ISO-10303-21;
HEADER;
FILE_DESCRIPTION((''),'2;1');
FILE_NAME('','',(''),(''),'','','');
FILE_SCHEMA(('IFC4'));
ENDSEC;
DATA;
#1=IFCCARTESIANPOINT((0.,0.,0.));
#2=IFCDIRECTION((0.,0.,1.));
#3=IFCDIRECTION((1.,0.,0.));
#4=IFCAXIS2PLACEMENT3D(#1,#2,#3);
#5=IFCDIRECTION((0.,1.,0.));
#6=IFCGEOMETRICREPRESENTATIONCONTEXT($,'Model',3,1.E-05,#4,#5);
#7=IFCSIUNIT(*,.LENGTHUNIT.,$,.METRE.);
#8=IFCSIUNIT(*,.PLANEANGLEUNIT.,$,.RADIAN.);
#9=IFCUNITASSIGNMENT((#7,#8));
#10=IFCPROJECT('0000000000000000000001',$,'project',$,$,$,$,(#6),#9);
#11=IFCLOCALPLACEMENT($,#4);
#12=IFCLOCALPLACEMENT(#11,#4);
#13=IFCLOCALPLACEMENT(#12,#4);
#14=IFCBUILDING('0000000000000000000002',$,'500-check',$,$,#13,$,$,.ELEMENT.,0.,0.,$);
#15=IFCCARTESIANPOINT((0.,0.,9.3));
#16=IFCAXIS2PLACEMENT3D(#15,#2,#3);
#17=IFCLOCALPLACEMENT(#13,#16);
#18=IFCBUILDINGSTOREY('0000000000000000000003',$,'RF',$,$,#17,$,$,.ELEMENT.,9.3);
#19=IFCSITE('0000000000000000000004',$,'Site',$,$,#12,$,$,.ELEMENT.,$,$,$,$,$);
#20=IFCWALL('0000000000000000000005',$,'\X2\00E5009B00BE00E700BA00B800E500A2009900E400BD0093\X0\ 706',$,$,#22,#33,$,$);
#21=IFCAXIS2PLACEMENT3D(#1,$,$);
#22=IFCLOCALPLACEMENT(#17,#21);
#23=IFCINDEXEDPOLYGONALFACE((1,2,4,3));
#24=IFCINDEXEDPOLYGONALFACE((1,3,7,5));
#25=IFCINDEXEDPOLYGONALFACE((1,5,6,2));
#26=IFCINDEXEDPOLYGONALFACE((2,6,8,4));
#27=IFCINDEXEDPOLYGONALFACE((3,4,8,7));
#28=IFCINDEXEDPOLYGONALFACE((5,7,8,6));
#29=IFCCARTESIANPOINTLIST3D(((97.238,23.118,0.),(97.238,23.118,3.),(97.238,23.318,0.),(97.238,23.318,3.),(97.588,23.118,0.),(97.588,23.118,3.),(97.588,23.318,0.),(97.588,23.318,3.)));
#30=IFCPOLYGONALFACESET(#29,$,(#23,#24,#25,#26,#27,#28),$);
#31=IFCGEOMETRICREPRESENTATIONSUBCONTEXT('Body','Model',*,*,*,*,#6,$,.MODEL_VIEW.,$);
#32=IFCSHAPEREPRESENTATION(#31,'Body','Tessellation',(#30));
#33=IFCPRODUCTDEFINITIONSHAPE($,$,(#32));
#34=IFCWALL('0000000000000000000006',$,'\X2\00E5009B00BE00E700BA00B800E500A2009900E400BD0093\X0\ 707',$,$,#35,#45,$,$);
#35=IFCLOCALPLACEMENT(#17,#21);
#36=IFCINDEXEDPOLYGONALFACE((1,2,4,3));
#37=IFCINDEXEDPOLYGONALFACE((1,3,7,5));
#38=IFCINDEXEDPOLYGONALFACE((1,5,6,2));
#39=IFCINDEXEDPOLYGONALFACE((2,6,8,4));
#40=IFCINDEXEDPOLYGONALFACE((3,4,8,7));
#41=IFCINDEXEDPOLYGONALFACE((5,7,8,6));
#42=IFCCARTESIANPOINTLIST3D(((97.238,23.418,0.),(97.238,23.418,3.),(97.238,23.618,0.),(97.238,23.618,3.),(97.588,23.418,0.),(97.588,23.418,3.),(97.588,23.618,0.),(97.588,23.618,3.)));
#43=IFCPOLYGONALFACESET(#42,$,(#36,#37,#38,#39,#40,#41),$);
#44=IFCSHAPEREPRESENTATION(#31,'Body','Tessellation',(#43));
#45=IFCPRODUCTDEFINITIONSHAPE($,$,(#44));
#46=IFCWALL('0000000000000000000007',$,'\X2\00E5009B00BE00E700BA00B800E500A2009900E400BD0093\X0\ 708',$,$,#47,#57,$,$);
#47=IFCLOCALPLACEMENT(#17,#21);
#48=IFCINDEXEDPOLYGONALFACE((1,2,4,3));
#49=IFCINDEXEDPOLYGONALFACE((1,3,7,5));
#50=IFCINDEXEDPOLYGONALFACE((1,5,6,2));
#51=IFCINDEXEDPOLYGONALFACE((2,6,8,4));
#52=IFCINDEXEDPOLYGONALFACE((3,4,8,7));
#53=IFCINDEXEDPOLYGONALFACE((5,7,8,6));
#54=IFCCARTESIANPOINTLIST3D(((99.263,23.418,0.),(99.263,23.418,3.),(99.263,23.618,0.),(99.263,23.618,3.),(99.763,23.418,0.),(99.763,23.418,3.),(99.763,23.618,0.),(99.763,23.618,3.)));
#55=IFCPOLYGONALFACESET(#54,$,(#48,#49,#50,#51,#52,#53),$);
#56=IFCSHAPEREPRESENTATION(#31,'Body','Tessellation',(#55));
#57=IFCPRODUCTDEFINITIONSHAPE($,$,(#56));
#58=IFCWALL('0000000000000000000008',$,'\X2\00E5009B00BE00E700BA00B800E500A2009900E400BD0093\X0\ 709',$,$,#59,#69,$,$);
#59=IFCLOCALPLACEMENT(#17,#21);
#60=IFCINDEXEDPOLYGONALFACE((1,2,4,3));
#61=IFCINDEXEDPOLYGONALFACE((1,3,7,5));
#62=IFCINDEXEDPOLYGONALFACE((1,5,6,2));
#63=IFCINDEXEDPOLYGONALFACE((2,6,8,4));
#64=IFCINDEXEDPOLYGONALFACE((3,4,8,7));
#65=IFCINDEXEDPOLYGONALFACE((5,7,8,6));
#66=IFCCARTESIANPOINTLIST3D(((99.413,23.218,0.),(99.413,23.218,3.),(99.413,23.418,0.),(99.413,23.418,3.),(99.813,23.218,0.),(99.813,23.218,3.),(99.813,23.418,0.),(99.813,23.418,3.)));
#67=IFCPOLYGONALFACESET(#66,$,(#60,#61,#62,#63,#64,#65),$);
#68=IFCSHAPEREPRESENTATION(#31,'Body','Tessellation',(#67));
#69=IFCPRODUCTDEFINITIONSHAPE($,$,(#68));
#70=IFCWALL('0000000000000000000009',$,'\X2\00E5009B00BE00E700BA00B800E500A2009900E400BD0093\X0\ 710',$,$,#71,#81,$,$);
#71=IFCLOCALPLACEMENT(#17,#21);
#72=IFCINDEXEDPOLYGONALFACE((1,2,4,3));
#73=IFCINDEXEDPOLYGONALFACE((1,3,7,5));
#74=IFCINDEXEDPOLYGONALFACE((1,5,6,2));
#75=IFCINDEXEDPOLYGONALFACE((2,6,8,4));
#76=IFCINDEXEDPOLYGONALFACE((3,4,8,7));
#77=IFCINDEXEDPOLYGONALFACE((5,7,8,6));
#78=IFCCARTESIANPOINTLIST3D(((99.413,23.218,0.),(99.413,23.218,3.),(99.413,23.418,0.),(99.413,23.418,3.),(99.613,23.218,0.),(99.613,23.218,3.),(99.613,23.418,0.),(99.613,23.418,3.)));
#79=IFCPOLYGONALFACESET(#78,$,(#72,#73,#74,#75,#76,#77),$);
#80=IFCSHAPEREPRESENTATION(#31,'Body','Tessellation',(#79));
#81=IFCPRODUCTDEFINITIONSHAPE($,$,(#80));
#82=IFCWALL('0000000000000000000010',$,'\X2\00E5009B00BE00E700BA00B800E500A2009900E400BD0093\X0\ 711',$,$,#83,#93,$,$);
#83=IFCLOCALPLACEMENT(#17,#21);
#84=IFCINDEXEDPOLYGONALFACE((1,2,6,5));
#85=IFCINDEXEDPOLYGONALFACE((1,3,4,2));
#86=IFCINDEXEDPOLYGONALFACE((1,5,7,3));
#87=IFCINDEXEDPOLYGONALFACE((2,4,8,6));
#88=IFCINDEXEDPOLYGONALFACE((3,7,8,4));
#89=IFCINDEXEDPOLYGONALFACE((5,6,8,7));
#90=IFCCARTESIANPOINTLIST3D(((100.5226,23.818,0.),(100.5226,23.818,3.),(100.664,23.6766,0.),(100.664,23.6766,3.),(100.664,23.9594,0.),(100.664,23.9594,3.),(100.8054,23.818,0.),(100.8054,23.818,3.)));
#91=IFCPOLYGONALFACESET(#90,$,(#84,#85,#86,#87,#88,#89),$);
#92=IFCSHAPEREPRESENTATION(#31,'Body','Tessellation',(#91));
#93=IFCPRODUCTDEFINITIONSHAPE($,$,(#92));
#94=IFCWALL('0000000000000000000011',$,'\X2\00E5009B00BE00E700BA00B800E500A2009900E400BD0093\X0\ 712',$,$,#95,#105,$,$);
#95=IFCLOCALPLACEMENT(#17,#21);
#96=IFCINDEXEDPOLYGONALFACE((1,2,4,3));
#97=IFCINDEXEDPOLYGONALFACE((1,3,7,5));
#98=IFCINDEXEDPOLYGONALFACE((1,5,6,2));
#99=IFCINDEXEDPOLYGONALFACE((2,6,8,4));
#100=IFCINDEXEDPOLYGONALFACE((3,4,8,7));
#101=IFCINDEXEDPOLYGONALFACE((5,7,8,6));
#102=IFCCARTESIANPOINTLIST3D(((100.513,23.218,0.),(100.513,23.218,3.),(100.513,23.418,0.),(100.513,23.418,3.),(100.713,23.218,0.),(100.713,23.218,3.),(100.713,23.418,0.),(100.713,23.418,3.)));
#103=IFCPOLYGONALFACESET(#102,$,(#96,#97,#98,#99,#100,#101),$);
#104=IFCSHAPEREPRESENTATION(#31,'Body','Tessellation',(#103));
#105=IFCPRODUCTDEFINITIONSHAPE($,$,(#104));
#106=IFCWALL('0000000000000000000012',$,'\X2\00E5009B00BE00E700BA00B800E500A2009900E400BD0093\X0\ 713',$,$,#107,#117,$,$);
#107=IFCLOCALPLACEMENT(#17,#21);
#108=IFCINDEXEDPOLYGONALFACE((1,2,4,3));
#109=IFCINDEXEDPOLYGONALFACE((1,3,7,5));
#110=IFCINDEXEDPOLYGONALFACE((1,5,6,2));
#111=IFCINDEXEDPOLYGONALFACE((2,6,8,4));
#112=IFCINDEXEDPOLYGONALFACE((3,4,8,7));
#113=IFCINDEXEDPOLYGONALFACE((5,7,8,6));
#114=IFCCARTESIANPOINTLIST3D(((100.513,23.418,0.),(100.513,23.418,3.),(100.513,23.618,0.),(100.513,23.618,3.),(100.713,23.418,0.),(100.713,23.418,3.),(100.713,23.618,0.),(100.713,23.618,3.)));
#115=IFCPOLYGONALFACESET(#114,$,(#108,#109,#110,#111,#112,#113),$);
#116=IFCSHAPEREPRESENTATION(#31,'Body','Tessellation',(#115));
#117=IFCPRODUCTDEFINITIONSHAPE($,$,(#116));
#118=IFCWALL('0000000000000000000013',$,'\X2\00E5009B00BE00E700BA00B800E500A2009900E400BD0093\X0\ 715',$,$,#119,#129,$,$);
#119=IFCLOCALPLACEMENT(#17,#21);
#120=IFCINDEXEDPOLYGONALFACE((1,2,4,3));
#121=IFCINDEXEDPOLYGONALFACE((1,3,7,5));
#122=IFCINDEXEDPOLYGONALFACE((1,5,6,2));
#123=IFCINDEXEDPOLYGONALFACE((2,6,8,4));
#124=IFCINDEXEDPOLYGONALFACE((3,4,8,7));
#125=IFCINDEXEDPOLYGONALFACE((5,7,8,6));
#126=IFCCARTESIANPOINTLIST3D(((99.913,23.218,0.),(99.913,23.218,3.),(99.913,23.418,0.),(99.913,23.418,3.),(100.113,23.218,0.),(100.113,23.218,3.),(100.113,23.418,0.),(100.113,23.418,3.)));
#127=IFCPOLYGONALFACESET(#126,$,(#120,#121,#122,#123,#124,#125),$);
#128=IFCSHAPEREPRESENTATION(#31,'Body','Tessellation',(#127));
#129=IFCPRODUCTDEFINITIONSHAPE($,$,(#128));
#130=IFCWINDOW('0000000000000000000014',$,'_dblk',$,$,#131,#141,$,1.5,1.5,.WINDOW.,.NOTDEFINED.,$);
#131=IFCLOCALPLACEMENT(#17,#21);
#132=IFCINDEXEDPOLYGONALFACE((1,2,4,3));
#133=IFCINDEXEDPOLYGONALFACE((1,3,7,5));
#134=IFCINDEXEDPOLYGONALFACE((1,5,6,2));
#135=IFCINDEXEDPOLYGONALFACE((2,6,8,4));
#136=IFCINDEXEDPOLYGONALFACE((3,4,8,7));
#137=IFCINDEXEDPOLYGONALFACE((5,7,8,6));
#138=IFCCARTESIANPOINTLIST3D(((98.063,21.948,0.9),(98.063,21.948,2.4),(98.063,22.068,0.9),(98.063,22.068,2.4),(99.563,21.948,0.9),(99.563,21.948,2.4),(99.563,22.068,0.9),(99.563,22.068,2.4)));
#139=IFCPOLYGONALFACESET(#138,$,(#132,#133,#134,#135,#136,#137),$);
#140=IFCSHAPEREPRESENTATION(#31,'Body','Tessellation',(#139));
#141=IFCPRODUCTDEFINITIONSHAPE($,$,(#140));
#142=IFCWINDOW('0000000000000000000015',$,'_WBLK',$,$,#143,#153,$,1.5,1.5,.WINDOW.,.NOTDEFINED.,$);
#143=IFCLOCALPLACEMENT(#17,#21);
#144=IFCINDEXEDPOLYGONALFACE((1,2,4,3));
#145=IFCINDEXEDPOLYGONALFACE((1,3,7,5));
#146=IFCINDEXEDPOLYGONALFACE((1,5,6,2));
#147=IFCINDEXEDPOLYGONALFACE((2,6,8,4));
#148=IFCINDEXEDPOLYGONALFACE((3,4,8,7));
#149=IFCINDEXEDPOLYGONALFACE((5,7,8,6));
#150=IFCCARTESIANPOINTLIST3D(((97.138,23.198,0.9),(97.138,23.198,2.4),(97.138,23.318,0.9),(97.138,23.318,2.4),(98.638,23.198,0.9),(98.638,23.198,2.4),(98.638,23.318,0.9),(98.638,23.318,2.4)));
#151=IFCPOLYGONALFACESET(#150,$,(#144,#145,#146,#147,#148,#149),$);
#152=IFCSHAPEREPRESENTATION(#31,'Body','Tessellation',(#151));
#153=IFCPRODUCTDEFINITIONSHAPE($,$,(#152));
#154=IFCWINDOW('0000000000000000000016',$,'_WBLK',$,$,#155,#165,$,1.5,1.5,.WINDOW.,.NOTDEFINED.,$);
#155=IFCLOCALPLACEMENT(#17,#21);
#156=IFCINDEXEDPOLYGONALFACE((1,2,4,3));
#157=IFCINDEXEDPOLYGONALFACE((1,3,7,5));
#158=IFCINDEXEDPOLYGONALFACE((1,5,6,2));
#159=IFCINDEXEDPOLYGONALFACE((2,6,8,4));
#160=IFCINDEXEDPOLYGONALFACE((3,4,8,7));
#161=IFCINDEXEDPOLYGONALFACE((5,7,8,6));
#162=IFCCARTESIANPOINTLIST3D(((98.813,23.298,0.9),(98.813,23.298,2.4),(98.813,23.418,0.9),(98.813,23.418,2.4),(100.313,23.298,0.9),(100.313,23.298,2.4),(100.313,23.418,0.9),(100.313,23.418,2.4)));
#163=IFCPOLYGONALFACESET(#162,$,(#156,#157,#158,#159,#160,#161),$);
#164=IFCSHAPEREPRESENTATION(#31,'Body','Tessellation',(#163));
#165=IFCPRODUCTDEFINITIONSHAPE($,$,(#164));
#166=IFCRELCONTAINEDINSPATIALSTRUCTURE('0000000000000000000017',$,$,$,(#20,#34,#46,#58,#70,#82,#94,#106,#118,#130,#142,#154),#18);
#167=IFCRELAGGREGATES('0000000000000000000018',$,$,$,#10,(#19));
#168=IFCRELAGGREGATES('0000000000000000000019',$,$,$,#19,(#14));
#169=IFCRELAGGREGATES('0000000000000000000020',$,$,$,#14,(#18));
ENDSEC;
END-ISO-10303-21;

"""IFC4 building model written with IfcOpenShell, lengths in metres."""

from ifc_helpers import new_model, si_unit, direction, frame, frame_2d, origin_with_axes, place, context, subcontext, project, spatial, rectangle, extrude, element, save


model = new_model("IFC4")

# Units and contexts
model_context = context("Model", 3, precision=1e-05, world=origin_with_axes(), true_north=direction((0.0, 1.0, 0.0)))
body_context = subcontext(model_context, "Body", "Model", "MODEL_VIEW")
ifc_project = project(units=[si_unit("LENGTHUNIT", "METRE"), si_unit("PLANEANGLEUNIT", "RADIAN")], contexts=[model_context])

# Site, building, storey
placement = place(None, origin_with_axes())
site_placement = place(placement, origin_with_axes())
site = spatial("IfcSite", under=ifc_project, at=site_placement, Name="Site", CompositionType="ELEMENT")
building_placement = place(site_placement, origin_with_axes())
building = spatial("IfcBuilding", under=site, at=building_placement, Name="500-check", CompositionType="ELEMENT", ElevationOfRefHeight=0.0, ElevationOfTerrain=0.0)
storey_placement = place(building_placement, frame((0.0, 0.0, 9.3), z_axis=(0.0, 0.0, 1.0), x_axis=(1.0, 0.0, 0.0)))
storey = spatial("IfcBuildingStorey", under=building, at=storey_placement, Name="RF", CompositionType="ELEMENT", Elevation=9.3)

# Walls
for number, where, z_axis, x_axis, name in (
    (1, (97.413, 23.218, 0.0), (0.0, 0.0, 1.0), (1.0, 0.0, 0.0), "å\u009b¾çº¸å¢\u0099ä½\u0093 706"),
    (2, (97.413, 23.518, 0.0), (0.0, 0.0, 1.0), (1.0, 0.0, 0.0), "å\u009b¾çº¸å¢\u0099ä½\u0093 707"),
):
    element("IfcWall", number, at=place(storey_placement, frame(where, z_axis=z_axis, x_axis=x_axis)), inside=storey, Name=name, context=body_context, shape_type="SweptSolid", body=[
        extrude(rectangle(XDim=0.35, YDim=0.2, at=frame_2d((0.0, 0.0), x_axis=(1.0, 0.0, 0.0))), frame((0.0, 0.0, 0.0), z_axis=(0.0, 0.0, 1.0)), (0.0, 0.0, 1.0), 3.0),
    ])
wall_1_placement = place(storey_placement, frame((99.513, 23.518, 0.0), z_axis=(0.0, 0.0, 1.0), x_axis=(1.0, 0.0, 0.0)))
element("IfcWall", 3, at=wall_1_placement, inside=storey, Name="å\u009b¾çº¸å¢\u0099ä½\u0093 708", context=body_context, shape_type="SweptSolid", body=[
    extrude(rectangle(XDim=0.5, YDim=0.2, at=frame_2d((0.0, 0.0), x_axis=(1.0, 0.0, 0.0))), frame((0.0, 0.0, 0.0), z_axis=(0.0, 0.0, 1.0)), (0.0, 0.0, 1.0), 3.0),
])
wall_2_placement = place(storey_placement, frame((99.613, 23.318, 0.0), z_axis=(0.0, 0.0, 1.0), x_axis=(1.0, 0.0, 0.0)))
element("IfcWall", 4, at=wall_2_placement, inside=storey, Name="å\u009b¾çº¸å¢\u0099ä½\u0093 709", context=body_context, shape_type="SweptSolid", body=[
    extrude(rectangle(XDim=0.4, YDim=0.2, at=frame_2d((0.0, 0.0), x_axis=(1.0, 0.0, 0.0))), frame((0.0, 0.0, 0.0), z_axis=(0.0, 0.0, 1.0)), (0.0, 0.0, 1.0), 3.0),
])
for number, where, z_axis, x_axis, name in (
    (5, (99.513, 23.318, 0.0), (0.0, 0.0, 1.0), (0.0, 1.0, 0.0), "å\u009b¾çº¸å¢\u0099ä½\u0093 710"),
    (6, (100.664, 23.818, 0.0), (0.0, 0.0, 1.0), (-0.707107, -0.707107, 0.0), "å\u009b¾çº¸å¢\u0099ä½\u0093 711"),
    (7, (100.613, 23.318, 0.0), (0.0, 0.0, 1.0), (1.0, 0.0, 0.0), "å\u009b¾çº¸å¢\u0099ä½\u0093 712"),
    (8, (100.613, 23.518, 0.0), (0.0, 0.0, 1.0), (1.0, 0.0, 0.0), "å\u009b¾çº¸å¢\u0099ä½\u0093 713"),
    (9, (100.013, 23.318, 0.0), (0.0, 0.0, 1.0), (0.0, 1.0, 0.0), "å\u009b¾çº¸å¢\u0099ä½\u0093 715"),
):
    element("IfcWall", number, at=place(storey_placement, frame(where, z_axis=z_axis, x_axis=x_axis)), inside=storey, Name=name, context=body_context, shape_type="SweptSolid", body=[
        extrude(rectangle(XDim=0.2, YDim=0.2, at=frame_2d((0.0, 0.0), x_axis=(1.0, 0.0, 0.0))), frame((0.0, 0.0, 0.0), z_axis=(0.0, 0.0, 1.0)), (0.0, 0.0, 1.0), 3.0),
    ])

# Windows
for number, where, z_axis, x_axis, name in (
    (10, (98.813, 22.008, 0.9), (0.0, 0.0, 1.0), (1.0, 0.0, 0.0), "_dblk"),
    (11, (97.888, 23.258, 0.9), (0.0, 0.0, 1.0), (1.0, 0.0, 0.0), "_WBLK"),
    (12, (99.563, 23.358, 0.9), (0.0, 0.0, 1.0), (1.0, 0.0, 0.0), "_WBLK"),
):
    element("IfcWindow", number, at=place(storey_placement, frame(where, z_axis=z_axis, x_axis=x_axis)), inside=storey, Name=name, OverallHeight=1.5, OverallWidth=1.5, PartitioningType="NOTDEFINED", PredefinedType="WINDOW", context=body_context, shape_type="SweptSolid", body=[
        extrude(rectangle(XDim=1.5, YDim=0.12, at=frame_2d((0.0, 0.0), x_axis=(1.0, 0.0, 0.0))), frame((0.0, 0.0, 0.0), z_axis=(0.0, 0.0, 1.0)), (0.0, 0.0, 1.0), 1.5),
    ])

save(model, "model.ifc")
